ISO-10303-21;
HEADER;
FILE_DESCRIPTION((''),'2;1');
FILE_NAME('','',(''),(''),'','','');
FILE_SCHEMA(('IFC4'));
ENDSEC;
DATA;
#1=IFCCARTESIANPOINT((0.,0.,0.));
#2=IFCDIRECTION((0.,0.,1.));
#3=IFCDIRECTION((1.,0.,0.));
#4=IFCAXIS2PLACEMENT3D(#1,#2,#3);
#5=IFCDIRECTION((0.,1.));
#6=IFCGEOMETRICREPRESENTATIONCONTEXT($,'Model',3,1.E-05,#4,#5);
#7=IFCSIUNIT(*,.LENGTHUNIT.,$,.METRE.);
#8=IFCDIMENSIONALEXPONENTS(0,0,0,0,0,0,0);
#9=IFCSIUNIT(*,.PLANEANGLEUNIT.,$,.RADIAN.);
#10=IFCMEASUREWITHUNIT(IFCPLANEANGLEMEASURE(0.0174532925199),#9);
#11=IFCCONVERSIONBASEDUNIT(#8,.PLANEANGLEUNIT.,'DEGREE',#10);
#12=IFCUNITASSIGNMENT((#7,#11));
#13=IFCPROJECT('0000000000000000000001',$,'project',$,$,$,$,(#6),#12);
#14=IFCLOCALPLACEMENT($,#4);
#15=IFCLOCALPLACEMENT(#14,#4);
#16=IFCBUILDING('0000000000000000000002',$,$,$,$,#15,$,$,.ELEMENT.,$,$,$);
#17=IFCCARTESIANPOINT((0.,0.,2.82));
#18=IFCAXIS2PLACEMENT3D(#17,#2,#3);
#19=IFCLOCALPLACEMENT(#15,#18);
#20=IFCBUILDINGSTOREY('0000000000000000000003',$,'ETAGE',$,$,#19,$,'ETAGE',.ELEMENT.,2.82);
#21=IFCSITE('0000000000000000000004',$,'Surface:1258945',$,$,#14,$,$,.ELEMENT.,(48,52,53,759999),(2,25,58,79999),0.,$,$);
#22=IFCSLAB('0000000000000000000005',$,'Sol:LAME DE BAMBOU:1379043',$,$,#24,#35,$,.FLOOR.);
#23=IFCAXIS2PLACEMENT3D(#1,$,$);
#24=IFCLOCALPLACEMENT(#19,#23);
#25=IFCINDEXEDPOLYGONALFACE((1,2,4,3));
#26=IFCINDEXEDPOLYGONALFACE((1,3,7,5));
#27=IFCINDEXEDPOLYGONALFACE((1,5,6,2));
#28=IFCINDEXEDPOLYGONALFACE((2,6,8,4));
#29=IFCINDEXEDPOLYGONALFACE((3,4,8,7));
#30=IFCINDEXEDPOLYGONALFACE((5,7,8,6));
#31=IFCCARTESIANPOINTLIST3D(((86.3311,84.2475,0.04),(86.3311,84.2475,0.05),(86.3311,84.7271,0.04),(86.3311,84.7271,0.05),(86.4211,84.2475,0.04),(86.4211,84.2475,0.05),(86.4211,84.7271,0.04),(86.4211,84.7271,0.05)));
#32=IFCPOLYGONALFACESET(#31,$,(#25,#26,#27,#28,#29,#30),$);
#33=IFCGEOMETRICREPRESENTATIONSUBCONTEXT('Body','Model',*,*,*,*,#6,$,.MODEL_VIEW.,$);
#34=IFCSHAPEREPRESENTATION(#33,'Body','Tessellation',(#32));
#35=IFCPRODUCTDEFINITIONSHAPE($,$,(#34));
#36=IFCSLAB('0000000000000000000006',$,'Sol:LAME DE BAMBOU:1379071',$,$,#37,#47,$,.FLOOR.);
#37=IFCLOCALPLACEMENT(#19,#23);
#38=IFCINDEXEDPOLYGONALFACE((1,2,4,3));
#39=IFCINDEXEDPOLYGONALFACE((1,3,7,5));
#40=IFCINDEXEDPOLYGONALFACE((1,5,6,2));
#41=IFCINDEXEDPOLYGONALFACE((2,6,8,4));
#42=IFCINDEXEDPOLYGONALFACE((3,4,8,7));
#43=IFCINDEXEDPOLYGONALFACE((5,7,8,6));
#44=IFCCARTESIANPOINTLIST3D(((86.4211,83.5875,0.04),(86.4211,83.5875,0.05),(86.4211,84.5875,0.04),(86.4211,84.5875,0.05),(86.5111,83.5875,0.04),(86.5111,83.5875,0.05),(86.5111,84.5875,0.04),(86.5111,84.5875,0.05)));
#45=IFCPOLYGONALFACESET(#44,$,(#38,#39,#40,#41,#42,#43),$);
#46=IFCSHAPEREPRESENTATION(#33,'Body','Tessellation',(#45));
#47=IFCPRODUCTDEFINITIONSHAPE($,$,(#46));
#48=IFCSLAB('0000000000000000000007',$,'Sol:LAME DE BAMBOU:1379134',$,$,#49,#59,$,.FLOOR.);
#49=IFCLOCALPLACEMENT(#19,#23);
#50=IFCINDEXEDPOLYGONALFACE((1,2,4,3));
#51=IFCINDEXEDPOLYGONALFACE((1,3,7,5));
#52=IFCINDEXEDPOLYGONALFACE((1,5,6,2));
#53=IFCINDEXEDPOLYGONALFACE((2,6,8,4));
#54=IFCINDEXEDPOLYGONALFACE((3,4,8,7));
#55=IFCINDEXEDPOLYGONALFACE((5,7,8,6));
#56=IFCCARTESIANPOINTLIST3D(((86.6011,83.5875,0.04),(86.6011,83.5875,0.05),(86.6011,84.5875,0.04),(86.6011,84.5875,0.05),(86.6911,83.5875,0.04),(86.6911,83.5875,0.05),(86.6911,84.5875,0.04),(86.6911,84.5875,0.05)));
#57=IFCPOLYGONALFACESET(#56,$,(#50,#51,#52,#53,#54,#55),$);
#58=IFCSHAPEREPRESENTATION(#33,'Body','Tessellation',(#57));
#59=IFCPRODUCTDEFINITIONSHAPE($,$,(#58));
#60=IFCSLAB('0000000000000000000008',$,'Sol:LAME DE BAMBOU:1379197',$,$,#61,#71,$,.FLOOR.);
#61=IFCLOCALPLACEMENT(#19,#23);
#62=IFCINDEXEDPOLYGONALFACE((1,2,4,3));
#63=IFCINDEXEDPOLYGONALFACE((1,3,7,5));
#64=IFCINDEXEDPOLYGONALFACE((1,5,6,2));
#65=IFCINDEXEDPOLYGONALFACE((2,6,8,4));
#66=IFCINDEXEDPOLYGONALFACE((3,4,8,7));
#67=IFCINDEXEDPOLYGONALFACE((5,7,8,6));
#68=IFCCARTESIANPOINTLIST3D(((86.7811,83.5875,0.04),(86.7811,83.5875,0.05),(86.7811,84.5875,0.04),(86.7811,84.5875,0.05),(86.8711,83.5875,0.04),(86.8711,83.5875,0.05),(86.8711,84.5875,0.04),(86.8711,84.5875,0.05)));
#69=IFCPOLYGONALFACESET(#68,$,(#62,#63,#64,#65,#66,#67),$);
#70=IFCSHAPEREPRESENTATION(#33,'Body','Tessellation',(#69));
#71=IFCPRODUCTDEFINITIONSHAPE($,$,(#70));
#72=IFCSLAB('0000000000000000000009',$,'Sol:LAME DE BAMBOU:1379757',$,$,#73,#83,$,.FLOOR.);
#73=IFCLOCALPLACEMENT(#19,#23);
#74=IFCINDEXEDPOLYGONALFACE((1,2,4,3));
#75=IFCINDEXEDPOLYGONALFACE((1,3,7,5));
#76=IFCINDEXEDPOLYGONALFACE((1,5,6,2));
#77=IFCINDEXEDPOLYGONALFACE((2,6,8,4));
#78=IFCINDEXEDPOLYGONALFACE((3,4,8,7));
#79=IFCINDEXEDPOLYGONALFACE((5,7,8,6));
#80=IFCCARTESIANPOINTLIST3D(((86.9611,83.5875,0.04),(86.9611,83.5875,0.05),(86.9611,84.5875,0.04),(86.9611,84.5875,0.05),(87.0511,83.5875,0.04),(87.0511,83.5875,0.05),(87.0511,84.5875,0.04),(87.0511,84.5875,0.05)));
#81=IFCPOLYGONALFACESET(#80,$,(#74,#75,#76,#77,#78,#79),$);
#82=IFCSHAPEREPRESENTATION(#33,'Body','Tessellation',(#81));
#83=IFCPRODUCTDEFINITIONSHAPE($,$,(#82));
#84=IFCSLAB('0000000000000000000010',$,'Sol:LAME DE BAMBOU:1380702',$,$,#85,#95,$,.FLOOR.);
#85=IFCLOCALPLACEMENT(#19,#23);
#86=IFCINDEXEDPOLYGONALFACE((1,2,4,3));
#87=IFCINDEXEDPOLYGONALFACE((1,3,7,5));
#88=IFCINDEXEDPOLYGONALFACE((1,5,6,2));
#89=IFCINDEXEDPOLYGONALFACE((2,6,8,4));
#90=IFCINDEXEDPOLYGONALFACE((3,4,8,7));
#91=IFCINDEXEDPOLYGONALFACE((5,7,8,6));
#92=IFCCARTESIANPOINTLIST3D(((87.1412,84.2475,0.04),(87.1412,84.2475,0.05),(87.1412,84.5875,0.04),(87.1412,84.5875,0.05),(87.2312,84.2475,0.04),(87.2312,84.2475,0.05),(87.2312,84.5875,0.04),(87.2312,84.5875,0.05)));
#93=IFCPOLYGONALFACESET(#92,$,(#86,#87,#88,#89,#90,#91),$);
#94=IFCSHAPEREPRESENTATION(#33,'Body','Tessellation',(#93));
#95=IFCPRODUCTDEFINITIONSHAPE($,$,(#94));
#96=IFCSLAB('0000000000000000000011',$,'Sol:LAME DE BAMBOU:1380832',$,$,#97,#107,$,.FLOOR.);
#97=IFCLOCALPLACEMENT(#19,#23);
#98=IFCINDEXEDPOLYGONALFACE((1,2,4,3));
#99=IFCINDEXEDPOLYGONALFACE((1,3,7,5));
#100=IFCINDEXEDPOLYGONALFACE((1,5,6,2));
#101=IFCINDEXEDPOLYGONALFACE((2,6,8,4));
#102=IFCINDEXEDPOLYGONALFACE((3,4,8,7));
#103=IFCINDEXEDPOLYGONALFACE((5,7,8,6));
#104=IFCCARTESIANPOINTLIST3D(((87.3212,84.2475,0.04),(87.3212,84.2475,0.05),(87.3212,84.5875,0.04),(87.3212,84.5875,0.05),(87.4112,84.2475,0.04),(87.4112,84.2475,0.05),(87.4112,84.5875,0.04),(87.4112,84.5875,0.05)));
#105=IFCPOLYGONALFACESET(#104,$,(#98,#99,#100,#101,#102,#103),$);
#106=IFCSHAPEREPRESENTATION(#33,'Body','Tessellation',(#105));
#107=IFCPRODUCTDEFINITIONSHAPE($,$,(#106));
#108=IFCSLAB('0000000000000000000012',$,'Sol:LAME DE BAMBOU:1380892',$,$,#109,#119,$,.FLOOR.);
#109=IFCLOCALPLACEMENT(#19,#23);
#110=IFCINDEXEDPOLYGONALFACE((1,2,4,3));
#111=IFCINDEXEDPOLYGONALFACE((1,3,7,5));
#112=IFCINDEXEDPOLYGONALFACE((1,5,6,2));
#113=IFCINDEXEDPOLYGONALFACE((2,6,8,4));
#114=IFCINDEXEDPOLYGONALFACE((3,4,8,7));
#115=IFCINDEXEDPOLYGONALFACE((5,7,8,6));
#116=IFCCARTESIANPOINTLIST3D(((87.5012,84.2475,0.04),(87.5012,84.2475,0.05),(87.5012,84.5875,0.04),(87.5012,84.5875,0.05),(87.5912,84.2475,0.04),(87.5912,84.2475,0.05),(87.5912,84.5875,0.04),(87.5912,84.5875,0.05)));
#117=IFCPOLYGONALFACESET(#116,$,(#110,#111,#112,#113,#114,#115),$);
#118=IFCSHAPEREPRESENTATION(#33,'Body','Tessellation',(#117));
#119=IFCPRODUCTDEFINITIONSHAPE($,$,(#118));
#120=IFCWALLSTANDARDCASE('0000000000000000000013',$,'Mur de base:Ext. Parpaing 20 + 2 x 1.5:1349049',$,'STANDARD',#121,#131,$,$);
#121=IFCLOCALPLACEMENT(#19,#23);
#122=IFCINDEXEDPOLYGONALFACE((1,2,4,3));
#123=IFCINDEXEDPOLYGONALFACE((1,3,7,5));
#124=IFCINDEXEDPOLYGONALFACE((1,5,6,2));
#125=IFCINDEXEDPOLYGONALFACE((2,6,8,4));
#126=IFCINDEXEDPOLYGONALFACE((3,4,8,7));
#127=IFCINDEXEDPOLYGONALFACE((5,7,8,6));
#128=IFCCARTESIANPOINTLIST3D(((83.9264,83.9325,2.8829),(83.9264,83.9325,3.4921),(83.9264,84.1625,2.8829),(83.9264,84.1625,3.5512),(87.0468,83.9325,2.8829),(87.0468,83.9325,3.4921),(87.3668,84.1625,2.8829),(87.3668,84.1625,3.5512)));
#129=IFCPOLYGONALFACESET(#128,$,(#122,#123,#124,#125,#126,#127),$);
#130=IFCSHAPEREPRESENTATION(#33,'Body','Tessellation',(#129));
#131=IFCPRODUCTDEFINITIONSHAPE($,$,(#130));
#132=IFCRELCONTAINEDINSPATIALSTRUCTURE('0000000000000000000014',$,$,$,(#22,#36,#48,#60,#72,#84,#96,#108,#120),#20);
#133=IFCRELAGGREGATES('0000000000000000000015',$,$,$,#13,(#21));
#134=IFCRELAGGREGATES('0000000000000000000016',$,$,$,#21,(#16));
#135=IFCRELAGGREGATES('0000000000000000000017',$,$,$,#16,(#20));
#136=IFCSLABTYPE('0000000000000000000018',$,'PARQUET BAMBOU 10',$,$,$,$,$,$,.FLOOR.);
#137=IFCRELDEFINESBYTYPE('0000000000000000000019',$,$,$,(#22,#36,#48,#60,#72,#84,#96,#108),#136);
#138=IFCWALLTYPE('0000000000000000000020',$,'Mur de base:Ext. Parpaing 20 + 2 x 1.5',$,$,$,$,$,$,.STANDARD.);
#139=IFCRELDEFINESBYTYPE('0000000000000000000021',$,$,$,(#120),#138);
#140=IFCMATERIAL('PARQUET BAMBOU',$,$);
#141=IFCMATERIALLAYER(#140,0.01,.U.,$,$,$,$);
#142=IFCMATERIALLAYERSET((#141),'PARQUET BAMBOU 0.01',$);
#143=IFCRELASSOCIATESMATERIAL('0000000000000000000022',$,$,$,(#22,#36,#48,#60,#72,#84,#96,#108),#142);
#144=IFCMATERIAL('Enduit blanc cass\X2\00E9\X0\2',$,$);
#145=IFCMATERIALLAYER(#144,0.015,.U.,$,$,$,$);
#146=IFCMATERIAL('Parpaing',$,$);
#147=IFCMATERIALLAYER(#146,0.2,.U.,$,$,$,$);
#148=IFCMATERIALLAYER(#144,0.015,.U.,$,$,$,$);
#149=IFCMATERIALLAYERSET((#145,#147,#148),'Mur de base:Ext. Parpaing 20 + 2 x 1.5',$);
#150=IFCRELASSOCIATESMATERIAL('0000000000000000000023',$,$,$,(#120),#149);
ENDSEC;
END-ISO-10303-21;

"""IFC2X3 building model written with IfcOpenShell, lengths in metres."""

from ifc_helpers import new_model, entity, si_unit, converted_unit, direction, frame, origin_with_axes, place, context, subcontext, project, spatial, polyline, outline, extrude, clip, halfspace, material, layer, layer_set, layer_usage, type_object, element, save


model = new_model("IFC2X3")

# Units and contexts
model_context = context("Model", 3, precision=1e-05, world=origin_with_axes(), true_north=direction((0.0, 1.0)))
body_context = subcontext(model_context, "Body", "Model", "MODEL_VIEW")
ifc_project = project(units=[si_unit("LENGTHUNIT", "METRE"), converted_unit("PLANEANGLEUNIT", "DEGREE", entity("IfcPlaneAngleMeasure", 0.0174532925199), si_unit("PLANEANGLEUNIT", "RADIAN"), dimensions=[0, 0, 0, 0, 0, 0, 0])], contexts=[model_context])

# Site, building, storey
site_placement = place(None, origin_with_axes())
site = spatial("IfcSite", under=ifc_project, at=site_placement, Name="Surface:1258945", CompositionType="ELEMENT", RefLatitude=(48, 52, 53, 759999), RefLongitude=(2, 25, 58, 79999), RefElevation=0.0)
building_placement = place(site_placement, origin_with_axes())
building = spatial("IfcBuilding", under=site, at=building_placement, CompositionType="ELEMENT")
storey_placement = place(building_placement, frame((0.0, 0.0, 2.82), z_axis=(0.0, 0.0, 1.0), x_axis=(1.0, 0.0, 0.0)))
storey = spatial("IfcBuildingStorey", under=building, at=storey_placement, Name="ETAGE", LongName="ETAGE", CompositionType="ELEMENT", Elevation=2.82)

# Slabs
ifc_material_1 = material(Name="PARQUET BAMBOU")
ifc_layer_1 = layer(ifc_material_1, 0.01, ventilated="UNKNOWN")
ifc_layer_set_1 = layer_set([ifc_layer_1], Name="PARQUET BAMBOU 0.01")
slab_type = type_object("IfcSlabType", Name="PARQUET BAMBOU 10", PredefinedType="FLOOR")
ifc_layer_usage_1 = layer_usage(ifc_layer_set_1, "AXIS3", "NEGATIVE", 0.01)
slab_1_placement = place(storey_placement, frame((86.3311, 84.7271, 0.05), z_axis=(0.0, 0.0, 1.0), x_axis=(1.0, 0.0, 0.0)))
element("IfcSlab", 1, at=slab_1_placement, inside=storey, type_object=slab_type, material=ifc_layer_usage_1, Name="Sol:LAME DE BAMBOU:1379043", PredefinedType="FLOOR", context=body_context, shape_type="SweptSolid", body=[
    extrude(outline(polyline([(0.0, 0.0), (0.0, -0.4796), (0.09, -0.4796), (0.09, 0.0), (0.0, 0.0)])), frame((0.0, 0.0, -0.01), z_axis=(0.0, 0.0, 1.0), x_axis=(1.0, 0.0, 0.0)), (0.0, 0.0, 1.0), 0.01),
])
ifc_layer_usage_2 = layer_usage(ifc_layer_set_1, "AXIS3", "NEGATIVE", 0.01)
slab_2_placement = place(storey_placement, frame((86.4211, 84.5875, 0.05), z_axis=(0.0, 0.0, 1.0), x_axis=(1.0, 0.0, 0.0)))
element("IfcSlab", 2, at=slab_2_placement, inside=storey, type_object=slab_type, material=ifc_layer_usage_2, Name="Sol:LAME DE BAMBOU:1379071", PredefinedType="FLOOR", context=body_context, shape_type="SweptSolid", body=[
    extrude(outline(polyline([(0.0, 0.0), (0.0, -1.0), (0.09, -1.0), (0.09, 0.0), (0.0, 0.0)])), frame((0.0, 0.0, -0.01), z_axis=(0.0, 0.0, 1.0), x_axis=(1.0, 0.0, 0.0)), (0.0, 0.0, 1.0), 0.01),
])
ifc_layer_usage_3 = layer_usage(ifc_layer_set_1, "AXIS3", "NEGATIVE", 0.01)
slab_3_placement = place(storey_placement, frame((86.6011, 84.5875, 0.05), z_axis=(0.0, 0.0, 1.0), x_axis=(1.0, 0.0, 0.0)))
element("IfcSlab", 3, at=slab_3_placement, inside=storey, type_object=slab_type, material=ifc_layer_usage_3, Name="Sol:LAME DE BAMBOU:1379134", PredefinedType="FLOOR", context=body_context, shape_type="SweptSolid", body=[
    extrude(outline(polyline([(0.0, 0.0), (0.0, -1.0), (0.09, -1.0), (0.09, 0.0), (0.0, 0.0)])), frame((0.0, 0.0, -0.01), z_axis=(0.0, 0.0, 1.0), x_axis=(1.0, 0.0, 0.0)), (0.0, 0.0, 1.0), 0.01),
])
ifc_layer_usage_4 = layer_usage(ifc_layer_set_1, "AXIS3", "NEGATIVE", 0.01)
slab_4_placement = place(storey_placement, frame((86.7811, 84.5875, 0.05), z_axis=(0.0, 0.0, 1.0), x_axis=(1.0, 0.0, 0.0)))
element("IfcSlab", 4, at=slab_4_placement, inside=storey, type_object=slab_type, material=ifc_layer_usage_4, Name="Sol:LAME DE BAMBOU:1379197", PredefinedType="FLOOR", context=body_context, shape_type="SweptSolid", body=[
    extrude(outline(polyline([(0.0, 0.0), (0.0, -1.0), (0.09, -1.0), (0.09, 0.0), (0.0, 0.0)])), frame((0.0, 0.0, -0.01), z_axis=(0.0, 0.0, 1.0), x_axis=(1.0, 0.0, 0.0)), (0.0, 0.0, 1.0), 0.01),
])
ifc_layer_usage_5 = layer_usage(ifc_layer_set_1, "AXIS3", "NEGATIVE", 0.01)
slab_5_placement = place(storey_placement, frame((86.9611, 84.5875, 0.05), z_axis=(0.0, 0.0, 1.0), x_axis=(1.0, 0.0, 0.0)))
element("IfcSlab", 5, at=slab_5_placement, inside=storey, type_object=slab_type, material=ifc_layer_usage_5, Name="Sol:LAME DE BAMBOU:1379757", PredefinedType="FLOOR", context=body_context, shape_type="SweptSolid", body=[
    extrude(outline(polyline([(0.0, 0.0), (0.0, -1.0), (0.09, -1.0), (0.09, 0.0), (0.0, 0.0)])), frame((0.0, 0.0, -0.01), z_axis=(0.0, 0.0, 1.0), x_axis=(1.0, 0.0, 0.0)), (0.0, 0.0, 1.0), 0.01),
])
ifc_layer_usage_6 = layer_usage(ifc_layer_set_1, "AXIS3", "NEGATIVE", 0.01)
slab_6_placement = place(storey_placement, frame((87.1412, 84.5875, 0.05), z_axis=(0.0, 0.0, 1.0), x_axis=(1.0, 0.0, 0.0)))
element("IfcSlab", 6, at=slab_6_placement, inside=storey, type_object=slab_type, material=ifc_layer_usage_6, Name="Sol:LAME DE BAMBOU:1380702", PredefinedType="FLOOR", context=body_context, shape_type="SweptSolid", body=[
    extrude(outline(polyline([(0.0, 0.0), (0.0, -0.34), (0.09, -0.34), (0.09, 0.0), (0.0, 0.0)])), frame((0.0, 0.0, -0.01), z_axis=(0.0, 0.0, 1.0), x_axis=(1.0, 0.0, 0.0)), (0.0, 0.0, 1.0), 0.01),
])
ifc_layer_usage_7 = layer_usage(ifc_layer_set_1, "AXIS3", "NEGATIVE", 0.01)
slab_7_placement = place(storey_placement, frame((87.3212, 84.5875, 0.05), z_axis=(0.0, 0.0, 1.0), x_axis=(1.0, 0.0, 0.0)))
element("IfcSlab", 7, at=slab_7_placement, inside=storey, type_object=slab_type, material=ifc_layer_usage_7, Name="Sol:LAME DE BAMBOU:1380832", PredefinedType="FLOOR", context=body_context, shape_type="SweptSolid", body=[
    extrude(outline(polyline([(0.0, 0.0), (0.0, -0.34), (0.09, -0.34), (0.09, 0.0), (0.0, 0.0)])), frame((0.0, 0.0, -0.01), z_axis=(0.0, 0.0, 1.0), x_axis=(1.0, 0.0, 0.0)), (0.0, 0.0, 1.0), 0.01),
])
ifc_layer_usage_8 = layer_usage(ifc_layer_set_1, "AXIS3", "NEGATIVE", 0.01)
slab_8_placement = place(storey_placement, frame((87.5012, 84.5875, 0.05), z_axis=(0.0, 0.0, 1.0), x_axis=(1.0, 0.0, 0.0)))
element("IfcSlab", 8, at=slab_8_placement, inside=storey, type_object=slab_type, material=ifc_layer_usage_8, Name="Sol:LAME DE BAMBOU:1380892", PredefinedType="FLOOR", context=body_context, shape_type="SweptSolid", body=[
    extrude(outline(polyline([(0.0, 0.0), (0.0, -0.34), (0.09, -0.34), (0.09, 0.0), (0.0, 0.0)])), frame((0.0, 0.0, -0.01), z_axis=(0.0, 0.0, 1.0), x_axis=(1.0, 0.0, 0.0)), (0.0, 0.0, 1.0), 0.01),
])

# Wall
ifc_material_2 = material(Name="Enduit blanc cassé2")
ifc_layer_2 = layer(ifc_material_2, 0.015, ventilated="UNKNOWN")
ifc_material_3 = material(Name="Parpaing")
ifc_layer_3 = layer(ifc_material_3, 0.2, ventilated="UNKNOWN")
ifc_layer_4 = layer(ifc_material_2, 0.015, ventilated="UNKNOWN")
ifc_layer_set_2 = layer_set([ifc_layer_2, ifc_layer_3, ifc_layer_4], Name="Mur de base:Ext. Parpaing 20 + 2 x 1.5")
ifc_layer_usage_9 = layer_usage(ifc_layer_set_2, "AXIS2", "POSITIVE", -0.115)
wall_type = type_object("IfcWallType", Name="Mur de base:Ext. Parpaing 20 + 2 x 1.5", PredefinedType="STANDARD")
wall_placement = place(storey_placement, frame((87.2068, 84.0475, 2.8829), z_axis=(0.0, 0.0, 1.0), x_axis=(-1.0, 0.0, 0.0)))
element("IfcWallStandardCase", 9, at=wall_placement, inside=storey, type_object=wall_type, material=ifc_layer_usage_9, Name="Mur de base:Ext. Parpaing 20 + 2 x 1.5:1349049", ObjectType="STANDARD", context=body_context, shape_type="Clipping", body=[
    clip(extrude(outline(polyline([(-0.16, -0.115), (3.2804, -0.115), (3.2804, 0.115), (0.16, 0.115), (-0.16, -0.115)])), origin_with_axes(), (0.0, 0.0, 1.0), 0.6683), halfspace(frame((0.0, 0.154, 0.5992), z_axis=(0.0, -0.248865, -0.968538), x_axis=(0.0, 0.968538, -0.248865)), True)),
])

save(model, "model.ifc")
